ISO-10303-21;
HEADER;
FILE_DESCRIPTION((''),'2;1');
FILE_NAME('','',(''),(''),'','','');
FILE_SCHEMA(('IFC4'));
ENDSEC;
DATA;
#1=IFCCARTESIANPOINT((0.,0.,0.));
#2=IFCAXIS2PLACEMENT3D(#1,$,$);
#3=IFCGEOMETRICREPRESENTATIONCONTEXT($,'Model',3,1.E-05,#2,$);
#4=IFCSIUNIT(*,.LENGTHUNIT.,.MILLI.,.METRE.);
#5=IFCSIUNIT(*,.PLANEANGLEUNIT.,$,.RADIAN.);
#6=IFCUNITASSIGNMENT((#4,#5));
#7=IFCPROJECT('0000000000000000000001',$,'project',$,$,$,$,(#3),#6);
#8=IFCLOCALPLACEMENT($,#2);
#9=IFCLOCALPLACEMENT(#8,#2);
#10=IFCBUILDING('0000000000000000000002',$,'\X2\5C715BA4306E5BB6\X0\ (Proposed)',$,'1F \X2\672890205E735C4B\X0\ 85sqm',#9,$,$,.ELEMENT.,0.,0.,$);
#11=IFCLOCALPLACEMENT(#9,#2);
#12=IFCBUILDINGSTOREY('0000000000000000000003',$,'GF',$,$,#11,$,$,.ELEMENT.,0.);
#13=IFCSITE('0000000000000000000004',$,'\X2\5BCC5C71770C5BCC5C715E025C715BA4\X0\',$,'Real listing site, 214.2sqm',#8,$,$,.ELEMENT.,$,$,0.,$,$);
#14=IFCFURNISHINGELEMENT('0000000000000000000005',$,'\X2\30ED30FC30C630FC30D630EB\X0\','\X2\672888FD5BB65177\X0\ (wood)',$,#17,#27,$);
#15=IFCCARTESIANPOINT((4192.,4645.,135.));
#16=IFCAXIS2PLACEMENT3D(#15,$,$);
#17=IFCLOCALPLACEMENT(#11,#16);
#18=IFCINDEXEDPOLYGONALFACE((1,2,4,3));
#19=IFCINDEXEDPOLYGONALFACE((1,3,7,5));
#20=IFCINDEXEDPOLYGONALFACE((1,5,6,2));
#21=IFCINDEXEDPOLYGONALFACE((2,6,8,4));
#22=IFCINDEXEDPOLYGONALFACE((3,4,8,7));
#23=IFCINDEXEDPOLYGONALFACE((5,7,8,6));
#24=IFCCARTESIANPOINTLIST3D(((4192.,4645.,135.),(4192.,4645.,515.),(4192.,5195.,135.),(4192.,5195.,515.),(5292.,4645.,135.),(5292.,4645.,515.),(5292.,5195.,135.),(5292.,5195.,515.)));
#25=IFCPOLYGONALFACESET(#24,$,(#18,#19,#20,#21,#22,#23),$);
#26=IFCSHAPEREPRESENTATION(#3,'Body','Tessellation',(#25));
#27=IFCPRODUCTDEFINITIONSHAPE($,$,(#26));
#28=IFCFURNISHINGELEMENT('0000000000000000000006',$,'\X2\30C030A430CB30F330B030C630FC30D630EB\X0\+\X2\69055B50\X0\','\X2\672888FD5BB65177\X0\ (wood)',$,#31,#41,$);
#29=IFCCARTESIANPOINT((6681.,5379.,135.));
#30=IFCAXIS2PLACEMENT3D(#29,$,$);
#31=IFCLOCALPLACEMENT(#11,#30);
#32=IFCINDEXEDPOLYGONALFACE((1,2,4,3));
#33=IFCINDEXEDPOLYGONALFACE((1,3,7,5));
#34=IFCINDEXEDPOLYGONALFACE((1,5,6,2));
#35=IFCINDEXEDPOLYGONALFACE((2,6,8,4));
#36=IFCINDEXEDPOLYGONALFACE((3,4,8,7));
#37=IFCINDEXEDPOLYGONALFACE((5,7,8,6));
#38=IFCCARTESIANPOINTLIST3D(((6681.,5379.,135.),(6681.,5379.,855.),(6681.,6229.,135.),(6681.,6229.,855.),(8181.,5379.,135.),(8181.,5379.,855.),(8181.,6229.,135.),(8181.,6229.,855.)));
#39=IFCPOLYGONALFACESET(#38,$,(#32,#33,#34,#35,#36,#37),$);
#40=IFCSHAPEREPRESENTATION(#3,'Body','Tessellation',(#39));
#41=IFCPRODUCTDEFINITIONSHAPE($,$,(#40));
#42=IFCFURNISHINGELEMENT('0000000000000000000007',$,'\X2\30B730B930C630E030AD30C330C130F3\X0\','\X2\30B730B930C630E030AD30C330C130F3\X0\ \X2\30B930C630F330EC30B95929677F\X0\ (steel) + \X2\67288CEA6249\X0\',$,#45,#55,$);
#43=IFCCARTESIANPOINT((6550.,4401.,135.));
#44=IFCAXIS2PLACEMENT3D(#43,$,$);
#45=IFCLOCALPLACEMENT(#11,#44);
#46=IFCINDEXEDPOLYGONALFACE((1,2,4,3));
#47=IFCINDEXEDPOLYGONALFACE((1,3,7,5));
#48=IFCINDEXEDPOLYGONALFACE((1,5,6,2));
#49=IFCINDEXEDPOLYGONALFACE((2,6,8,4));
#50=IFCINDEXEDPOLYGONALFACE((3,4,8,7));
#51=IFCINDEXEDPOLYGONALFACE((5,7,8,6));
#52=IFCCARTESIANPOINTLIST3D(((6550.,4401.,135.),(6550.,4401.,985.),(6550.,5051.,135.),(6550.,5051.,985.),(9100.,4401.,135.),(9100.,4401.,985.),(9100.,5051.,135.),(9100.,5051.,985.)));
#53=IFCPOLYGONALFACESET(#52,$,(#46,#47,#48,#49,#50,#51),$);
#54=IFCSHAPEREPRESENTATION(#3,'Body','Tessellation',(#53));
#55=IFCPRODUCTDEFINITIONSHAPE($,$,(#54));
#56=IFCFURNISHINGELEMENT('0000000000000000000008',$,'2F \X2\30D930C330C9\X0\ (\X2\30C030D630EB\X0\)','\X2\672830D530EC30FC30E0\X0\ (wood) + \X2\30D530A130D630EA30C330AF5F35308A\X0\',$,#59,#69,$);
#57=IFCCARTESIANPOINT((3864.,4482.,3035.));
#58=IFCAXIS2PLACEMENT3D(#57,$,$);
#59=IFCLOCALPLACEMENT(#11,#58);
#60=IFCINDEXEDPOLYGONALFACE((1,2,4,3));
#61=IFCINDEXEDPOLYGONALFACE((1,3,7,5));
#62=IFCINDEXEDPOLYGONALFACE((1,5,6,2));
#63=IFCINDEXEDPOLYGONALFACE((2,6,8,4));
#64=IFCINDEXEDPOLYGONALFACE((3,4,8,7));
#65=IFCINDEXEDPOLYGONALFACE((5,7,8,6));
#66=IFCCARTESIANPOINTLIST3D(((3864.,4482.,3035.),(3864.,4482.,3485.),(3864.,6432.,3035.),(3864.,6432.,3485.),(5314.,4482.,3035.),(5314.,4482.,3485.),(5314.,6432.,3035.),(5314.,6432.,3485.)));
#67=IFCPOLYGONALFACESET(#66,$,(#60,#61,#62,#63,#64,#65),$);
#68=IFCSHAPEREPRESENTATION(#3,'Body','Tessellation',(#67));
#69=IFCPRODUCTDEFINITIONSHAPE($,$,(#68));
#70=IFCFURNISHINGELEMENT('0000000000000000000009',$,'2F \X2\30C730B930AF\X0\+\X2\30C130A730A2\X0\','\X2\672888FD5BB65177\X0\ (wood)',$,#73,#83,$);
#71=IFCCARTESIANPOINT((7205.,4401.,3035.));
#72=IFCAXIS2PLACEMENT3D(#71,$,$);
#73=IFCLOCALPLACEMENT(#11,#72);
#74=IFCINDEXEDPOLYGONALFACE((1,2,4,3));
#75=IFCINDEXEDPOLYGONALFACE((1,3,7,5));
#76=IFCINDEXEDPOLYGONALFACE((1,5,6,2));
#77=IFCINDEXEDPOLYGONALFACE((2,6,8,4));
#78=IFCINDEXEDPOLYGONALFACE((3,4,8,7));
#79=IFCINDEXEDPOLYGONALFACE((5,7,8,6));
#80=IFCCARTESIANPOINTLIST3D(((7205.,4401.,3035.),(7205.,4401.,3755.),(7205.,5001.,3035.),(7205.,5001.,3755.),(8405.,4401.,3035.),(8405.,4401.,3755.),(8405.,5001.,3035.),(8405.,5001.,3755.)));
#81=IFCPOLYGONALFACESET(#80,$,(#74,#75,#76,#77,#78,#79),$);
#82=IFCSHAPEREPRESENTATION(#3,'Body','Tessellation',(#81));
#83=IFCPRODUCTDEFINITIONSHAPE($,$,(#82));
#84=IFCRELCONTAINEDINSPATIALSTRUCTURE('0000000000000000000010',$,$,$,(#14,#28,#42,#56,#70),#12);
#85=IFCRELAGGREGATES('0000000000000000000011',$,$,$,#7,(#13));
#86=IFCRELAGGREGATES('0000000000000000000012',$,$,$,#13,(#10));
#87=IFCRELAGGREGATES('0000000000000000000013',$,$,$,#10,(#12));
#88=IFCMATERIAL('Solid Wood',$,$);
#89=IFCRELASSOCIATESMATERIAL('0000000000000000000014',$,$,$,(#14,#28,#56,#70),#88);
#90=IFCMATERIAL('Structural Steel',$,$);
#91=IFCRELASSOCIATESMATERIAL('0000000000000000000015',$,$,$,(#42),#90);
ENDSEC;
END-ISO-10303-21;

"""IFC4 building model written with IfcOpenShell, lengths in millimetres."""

from ifc_helpers import new_model, si_unit, frame, frame_2d, origin, place, context, project, spatial, rectangle, extrude, material, element, save


model = new_model("IFC4")

# Units and contexts
model_context = context("Model", 3, precision=1e-05, world=origin())
ifc_project = project(units=[si_unit("LENGTHUNIT", "METRE", prefix="MILLI"), si_unit("PLANEANGLEUNIT", "RADIAN")], contexts=[model_context])

# Site, building, storey
site_placement = place(None, origin())
site = spatial("IfcSite", under=ifc_project, at=site_placement, Name="富山県富山市山室", ObjectType="Real listing site, 214.2sqm", CompositionType="ELEMENT", RefElevation=0.0)
building_placement = place(site_placement, origin())
building = spatial("IfcBuilding", under=site, at=building_placement, Name="山室の家 (Proposed)", ObjectType="1F 木造平屋 85sqm", CompositionType="ELEMENT", ElevationOfRefHeight=0.0, ElevationOfTerrain=0.0)
storey_placement = place(building_placement, origin())
storey = spatial("IfcBuildingStorey", under=building, at=storey_placement, Name="GF", CompositionType="ELEMENT", Elevation=0.0)

# Shared definitions
ifc_material_1 = material(Name="Solid Wood")

# Shared definitions
ifc_material_2 = material(Name="Structural Steel")

# Furnishing elements
furnishing_1_placement = place(storey_placement, frame((4192.0, 4645.0, 135.0)))
element("IfcFurnishingElement", 1, at=furnishing_1_placement, inside=storey, material=ifc_material_1, Name="ローテーブル", Description="木製家具 (wood)", context=model_context, shape_type="SweptSolid", body=[
    extrude(rectangle(XDim=1100.0, YDim=550.0, at=frame_2d((550.0, 275.0))), frame((4192.0, 4645.0, 135.0)), (0.0, 0.0, 1.0), 380.0),
])
furnishing_2_placement = place(storey_placement, frame((6681.0, 5379.0, 135.0)))
element("IfcFurnishingElement", 2, at=furnishing_2_placement, inside=storey, material=ifc_material_1, Name="ダイニングテーブル+椅子", Description="木製家具 (wood)", context=model_context, shape_type="SweptSolid", body=[
    extrude(rectangle(XDim=1500.0, YDim=850.0, at=frame_2d((750.0, 425.0))), frame((6681.0, 5379.0, 135.0)), (0.0, 0.0, 1.0), 720.0),
])
furnishing_3_placement = place(storey_placement, frame((6550.0, 4401.0, 135.0)))
element("IfcFurnishingElement", 3, at=furnishing_3_placement, inside=storey, material=ifc_material_2, Name="システムキッチン", Description="システムキッチン ステンレス天板 (steel) + 木質扉", context=model_context, shape_type="SweptSolid", body=[
    extrude(rectangle(XDim=2550.0, YDim=650.0, at=frame_2d((1275.0, 325.0))), frame((6550.0, 4401.0, 135.0)), (0.0, 0.0, 1.0), 850.0),
])
furnishing_4_placement = place(storey_placement, frame((3864.0, 4482.0, 3035.0)))
element("IfcFurnishingElement", 4, at=furnishing_4_placement, inside=storey, material=ifc_material_1, Name="2F ベッド (ダブル)", Description="木フレーム (wood) + ファブリック張り", context=model_context, shape_type="SweptSolid", body=[
    extrude(rectangle(XDim=1450.0, YDim=1950.0, at=frame_2d((725.0, 975.0))), frame((3864.0, 4482.0, 3035.0)), (0.0, 0.0, 1.0), 450.0),
])
furnishing_5_placement = place(storey_placement, frame((7205.0, 4401.0, 3035.0)))
element("IfcFurnishingElement", 5, at=furnishing_5_placement, inside=storey, material=ifc_material_1, Name="2F デスク+チェア", Description="木製家具 (wood)", context=model_context, shape_type="SweptSolid", body=[
    extrude(rectangle(XDim=1200.0, YDim=600.0, at=frame_2d((600.0, 300.0))), frame((7205.0, 4401.0, 3035.0)), (0.0, 0.0, 1.0), 720.0),
])

save(model, "model.ifc")
